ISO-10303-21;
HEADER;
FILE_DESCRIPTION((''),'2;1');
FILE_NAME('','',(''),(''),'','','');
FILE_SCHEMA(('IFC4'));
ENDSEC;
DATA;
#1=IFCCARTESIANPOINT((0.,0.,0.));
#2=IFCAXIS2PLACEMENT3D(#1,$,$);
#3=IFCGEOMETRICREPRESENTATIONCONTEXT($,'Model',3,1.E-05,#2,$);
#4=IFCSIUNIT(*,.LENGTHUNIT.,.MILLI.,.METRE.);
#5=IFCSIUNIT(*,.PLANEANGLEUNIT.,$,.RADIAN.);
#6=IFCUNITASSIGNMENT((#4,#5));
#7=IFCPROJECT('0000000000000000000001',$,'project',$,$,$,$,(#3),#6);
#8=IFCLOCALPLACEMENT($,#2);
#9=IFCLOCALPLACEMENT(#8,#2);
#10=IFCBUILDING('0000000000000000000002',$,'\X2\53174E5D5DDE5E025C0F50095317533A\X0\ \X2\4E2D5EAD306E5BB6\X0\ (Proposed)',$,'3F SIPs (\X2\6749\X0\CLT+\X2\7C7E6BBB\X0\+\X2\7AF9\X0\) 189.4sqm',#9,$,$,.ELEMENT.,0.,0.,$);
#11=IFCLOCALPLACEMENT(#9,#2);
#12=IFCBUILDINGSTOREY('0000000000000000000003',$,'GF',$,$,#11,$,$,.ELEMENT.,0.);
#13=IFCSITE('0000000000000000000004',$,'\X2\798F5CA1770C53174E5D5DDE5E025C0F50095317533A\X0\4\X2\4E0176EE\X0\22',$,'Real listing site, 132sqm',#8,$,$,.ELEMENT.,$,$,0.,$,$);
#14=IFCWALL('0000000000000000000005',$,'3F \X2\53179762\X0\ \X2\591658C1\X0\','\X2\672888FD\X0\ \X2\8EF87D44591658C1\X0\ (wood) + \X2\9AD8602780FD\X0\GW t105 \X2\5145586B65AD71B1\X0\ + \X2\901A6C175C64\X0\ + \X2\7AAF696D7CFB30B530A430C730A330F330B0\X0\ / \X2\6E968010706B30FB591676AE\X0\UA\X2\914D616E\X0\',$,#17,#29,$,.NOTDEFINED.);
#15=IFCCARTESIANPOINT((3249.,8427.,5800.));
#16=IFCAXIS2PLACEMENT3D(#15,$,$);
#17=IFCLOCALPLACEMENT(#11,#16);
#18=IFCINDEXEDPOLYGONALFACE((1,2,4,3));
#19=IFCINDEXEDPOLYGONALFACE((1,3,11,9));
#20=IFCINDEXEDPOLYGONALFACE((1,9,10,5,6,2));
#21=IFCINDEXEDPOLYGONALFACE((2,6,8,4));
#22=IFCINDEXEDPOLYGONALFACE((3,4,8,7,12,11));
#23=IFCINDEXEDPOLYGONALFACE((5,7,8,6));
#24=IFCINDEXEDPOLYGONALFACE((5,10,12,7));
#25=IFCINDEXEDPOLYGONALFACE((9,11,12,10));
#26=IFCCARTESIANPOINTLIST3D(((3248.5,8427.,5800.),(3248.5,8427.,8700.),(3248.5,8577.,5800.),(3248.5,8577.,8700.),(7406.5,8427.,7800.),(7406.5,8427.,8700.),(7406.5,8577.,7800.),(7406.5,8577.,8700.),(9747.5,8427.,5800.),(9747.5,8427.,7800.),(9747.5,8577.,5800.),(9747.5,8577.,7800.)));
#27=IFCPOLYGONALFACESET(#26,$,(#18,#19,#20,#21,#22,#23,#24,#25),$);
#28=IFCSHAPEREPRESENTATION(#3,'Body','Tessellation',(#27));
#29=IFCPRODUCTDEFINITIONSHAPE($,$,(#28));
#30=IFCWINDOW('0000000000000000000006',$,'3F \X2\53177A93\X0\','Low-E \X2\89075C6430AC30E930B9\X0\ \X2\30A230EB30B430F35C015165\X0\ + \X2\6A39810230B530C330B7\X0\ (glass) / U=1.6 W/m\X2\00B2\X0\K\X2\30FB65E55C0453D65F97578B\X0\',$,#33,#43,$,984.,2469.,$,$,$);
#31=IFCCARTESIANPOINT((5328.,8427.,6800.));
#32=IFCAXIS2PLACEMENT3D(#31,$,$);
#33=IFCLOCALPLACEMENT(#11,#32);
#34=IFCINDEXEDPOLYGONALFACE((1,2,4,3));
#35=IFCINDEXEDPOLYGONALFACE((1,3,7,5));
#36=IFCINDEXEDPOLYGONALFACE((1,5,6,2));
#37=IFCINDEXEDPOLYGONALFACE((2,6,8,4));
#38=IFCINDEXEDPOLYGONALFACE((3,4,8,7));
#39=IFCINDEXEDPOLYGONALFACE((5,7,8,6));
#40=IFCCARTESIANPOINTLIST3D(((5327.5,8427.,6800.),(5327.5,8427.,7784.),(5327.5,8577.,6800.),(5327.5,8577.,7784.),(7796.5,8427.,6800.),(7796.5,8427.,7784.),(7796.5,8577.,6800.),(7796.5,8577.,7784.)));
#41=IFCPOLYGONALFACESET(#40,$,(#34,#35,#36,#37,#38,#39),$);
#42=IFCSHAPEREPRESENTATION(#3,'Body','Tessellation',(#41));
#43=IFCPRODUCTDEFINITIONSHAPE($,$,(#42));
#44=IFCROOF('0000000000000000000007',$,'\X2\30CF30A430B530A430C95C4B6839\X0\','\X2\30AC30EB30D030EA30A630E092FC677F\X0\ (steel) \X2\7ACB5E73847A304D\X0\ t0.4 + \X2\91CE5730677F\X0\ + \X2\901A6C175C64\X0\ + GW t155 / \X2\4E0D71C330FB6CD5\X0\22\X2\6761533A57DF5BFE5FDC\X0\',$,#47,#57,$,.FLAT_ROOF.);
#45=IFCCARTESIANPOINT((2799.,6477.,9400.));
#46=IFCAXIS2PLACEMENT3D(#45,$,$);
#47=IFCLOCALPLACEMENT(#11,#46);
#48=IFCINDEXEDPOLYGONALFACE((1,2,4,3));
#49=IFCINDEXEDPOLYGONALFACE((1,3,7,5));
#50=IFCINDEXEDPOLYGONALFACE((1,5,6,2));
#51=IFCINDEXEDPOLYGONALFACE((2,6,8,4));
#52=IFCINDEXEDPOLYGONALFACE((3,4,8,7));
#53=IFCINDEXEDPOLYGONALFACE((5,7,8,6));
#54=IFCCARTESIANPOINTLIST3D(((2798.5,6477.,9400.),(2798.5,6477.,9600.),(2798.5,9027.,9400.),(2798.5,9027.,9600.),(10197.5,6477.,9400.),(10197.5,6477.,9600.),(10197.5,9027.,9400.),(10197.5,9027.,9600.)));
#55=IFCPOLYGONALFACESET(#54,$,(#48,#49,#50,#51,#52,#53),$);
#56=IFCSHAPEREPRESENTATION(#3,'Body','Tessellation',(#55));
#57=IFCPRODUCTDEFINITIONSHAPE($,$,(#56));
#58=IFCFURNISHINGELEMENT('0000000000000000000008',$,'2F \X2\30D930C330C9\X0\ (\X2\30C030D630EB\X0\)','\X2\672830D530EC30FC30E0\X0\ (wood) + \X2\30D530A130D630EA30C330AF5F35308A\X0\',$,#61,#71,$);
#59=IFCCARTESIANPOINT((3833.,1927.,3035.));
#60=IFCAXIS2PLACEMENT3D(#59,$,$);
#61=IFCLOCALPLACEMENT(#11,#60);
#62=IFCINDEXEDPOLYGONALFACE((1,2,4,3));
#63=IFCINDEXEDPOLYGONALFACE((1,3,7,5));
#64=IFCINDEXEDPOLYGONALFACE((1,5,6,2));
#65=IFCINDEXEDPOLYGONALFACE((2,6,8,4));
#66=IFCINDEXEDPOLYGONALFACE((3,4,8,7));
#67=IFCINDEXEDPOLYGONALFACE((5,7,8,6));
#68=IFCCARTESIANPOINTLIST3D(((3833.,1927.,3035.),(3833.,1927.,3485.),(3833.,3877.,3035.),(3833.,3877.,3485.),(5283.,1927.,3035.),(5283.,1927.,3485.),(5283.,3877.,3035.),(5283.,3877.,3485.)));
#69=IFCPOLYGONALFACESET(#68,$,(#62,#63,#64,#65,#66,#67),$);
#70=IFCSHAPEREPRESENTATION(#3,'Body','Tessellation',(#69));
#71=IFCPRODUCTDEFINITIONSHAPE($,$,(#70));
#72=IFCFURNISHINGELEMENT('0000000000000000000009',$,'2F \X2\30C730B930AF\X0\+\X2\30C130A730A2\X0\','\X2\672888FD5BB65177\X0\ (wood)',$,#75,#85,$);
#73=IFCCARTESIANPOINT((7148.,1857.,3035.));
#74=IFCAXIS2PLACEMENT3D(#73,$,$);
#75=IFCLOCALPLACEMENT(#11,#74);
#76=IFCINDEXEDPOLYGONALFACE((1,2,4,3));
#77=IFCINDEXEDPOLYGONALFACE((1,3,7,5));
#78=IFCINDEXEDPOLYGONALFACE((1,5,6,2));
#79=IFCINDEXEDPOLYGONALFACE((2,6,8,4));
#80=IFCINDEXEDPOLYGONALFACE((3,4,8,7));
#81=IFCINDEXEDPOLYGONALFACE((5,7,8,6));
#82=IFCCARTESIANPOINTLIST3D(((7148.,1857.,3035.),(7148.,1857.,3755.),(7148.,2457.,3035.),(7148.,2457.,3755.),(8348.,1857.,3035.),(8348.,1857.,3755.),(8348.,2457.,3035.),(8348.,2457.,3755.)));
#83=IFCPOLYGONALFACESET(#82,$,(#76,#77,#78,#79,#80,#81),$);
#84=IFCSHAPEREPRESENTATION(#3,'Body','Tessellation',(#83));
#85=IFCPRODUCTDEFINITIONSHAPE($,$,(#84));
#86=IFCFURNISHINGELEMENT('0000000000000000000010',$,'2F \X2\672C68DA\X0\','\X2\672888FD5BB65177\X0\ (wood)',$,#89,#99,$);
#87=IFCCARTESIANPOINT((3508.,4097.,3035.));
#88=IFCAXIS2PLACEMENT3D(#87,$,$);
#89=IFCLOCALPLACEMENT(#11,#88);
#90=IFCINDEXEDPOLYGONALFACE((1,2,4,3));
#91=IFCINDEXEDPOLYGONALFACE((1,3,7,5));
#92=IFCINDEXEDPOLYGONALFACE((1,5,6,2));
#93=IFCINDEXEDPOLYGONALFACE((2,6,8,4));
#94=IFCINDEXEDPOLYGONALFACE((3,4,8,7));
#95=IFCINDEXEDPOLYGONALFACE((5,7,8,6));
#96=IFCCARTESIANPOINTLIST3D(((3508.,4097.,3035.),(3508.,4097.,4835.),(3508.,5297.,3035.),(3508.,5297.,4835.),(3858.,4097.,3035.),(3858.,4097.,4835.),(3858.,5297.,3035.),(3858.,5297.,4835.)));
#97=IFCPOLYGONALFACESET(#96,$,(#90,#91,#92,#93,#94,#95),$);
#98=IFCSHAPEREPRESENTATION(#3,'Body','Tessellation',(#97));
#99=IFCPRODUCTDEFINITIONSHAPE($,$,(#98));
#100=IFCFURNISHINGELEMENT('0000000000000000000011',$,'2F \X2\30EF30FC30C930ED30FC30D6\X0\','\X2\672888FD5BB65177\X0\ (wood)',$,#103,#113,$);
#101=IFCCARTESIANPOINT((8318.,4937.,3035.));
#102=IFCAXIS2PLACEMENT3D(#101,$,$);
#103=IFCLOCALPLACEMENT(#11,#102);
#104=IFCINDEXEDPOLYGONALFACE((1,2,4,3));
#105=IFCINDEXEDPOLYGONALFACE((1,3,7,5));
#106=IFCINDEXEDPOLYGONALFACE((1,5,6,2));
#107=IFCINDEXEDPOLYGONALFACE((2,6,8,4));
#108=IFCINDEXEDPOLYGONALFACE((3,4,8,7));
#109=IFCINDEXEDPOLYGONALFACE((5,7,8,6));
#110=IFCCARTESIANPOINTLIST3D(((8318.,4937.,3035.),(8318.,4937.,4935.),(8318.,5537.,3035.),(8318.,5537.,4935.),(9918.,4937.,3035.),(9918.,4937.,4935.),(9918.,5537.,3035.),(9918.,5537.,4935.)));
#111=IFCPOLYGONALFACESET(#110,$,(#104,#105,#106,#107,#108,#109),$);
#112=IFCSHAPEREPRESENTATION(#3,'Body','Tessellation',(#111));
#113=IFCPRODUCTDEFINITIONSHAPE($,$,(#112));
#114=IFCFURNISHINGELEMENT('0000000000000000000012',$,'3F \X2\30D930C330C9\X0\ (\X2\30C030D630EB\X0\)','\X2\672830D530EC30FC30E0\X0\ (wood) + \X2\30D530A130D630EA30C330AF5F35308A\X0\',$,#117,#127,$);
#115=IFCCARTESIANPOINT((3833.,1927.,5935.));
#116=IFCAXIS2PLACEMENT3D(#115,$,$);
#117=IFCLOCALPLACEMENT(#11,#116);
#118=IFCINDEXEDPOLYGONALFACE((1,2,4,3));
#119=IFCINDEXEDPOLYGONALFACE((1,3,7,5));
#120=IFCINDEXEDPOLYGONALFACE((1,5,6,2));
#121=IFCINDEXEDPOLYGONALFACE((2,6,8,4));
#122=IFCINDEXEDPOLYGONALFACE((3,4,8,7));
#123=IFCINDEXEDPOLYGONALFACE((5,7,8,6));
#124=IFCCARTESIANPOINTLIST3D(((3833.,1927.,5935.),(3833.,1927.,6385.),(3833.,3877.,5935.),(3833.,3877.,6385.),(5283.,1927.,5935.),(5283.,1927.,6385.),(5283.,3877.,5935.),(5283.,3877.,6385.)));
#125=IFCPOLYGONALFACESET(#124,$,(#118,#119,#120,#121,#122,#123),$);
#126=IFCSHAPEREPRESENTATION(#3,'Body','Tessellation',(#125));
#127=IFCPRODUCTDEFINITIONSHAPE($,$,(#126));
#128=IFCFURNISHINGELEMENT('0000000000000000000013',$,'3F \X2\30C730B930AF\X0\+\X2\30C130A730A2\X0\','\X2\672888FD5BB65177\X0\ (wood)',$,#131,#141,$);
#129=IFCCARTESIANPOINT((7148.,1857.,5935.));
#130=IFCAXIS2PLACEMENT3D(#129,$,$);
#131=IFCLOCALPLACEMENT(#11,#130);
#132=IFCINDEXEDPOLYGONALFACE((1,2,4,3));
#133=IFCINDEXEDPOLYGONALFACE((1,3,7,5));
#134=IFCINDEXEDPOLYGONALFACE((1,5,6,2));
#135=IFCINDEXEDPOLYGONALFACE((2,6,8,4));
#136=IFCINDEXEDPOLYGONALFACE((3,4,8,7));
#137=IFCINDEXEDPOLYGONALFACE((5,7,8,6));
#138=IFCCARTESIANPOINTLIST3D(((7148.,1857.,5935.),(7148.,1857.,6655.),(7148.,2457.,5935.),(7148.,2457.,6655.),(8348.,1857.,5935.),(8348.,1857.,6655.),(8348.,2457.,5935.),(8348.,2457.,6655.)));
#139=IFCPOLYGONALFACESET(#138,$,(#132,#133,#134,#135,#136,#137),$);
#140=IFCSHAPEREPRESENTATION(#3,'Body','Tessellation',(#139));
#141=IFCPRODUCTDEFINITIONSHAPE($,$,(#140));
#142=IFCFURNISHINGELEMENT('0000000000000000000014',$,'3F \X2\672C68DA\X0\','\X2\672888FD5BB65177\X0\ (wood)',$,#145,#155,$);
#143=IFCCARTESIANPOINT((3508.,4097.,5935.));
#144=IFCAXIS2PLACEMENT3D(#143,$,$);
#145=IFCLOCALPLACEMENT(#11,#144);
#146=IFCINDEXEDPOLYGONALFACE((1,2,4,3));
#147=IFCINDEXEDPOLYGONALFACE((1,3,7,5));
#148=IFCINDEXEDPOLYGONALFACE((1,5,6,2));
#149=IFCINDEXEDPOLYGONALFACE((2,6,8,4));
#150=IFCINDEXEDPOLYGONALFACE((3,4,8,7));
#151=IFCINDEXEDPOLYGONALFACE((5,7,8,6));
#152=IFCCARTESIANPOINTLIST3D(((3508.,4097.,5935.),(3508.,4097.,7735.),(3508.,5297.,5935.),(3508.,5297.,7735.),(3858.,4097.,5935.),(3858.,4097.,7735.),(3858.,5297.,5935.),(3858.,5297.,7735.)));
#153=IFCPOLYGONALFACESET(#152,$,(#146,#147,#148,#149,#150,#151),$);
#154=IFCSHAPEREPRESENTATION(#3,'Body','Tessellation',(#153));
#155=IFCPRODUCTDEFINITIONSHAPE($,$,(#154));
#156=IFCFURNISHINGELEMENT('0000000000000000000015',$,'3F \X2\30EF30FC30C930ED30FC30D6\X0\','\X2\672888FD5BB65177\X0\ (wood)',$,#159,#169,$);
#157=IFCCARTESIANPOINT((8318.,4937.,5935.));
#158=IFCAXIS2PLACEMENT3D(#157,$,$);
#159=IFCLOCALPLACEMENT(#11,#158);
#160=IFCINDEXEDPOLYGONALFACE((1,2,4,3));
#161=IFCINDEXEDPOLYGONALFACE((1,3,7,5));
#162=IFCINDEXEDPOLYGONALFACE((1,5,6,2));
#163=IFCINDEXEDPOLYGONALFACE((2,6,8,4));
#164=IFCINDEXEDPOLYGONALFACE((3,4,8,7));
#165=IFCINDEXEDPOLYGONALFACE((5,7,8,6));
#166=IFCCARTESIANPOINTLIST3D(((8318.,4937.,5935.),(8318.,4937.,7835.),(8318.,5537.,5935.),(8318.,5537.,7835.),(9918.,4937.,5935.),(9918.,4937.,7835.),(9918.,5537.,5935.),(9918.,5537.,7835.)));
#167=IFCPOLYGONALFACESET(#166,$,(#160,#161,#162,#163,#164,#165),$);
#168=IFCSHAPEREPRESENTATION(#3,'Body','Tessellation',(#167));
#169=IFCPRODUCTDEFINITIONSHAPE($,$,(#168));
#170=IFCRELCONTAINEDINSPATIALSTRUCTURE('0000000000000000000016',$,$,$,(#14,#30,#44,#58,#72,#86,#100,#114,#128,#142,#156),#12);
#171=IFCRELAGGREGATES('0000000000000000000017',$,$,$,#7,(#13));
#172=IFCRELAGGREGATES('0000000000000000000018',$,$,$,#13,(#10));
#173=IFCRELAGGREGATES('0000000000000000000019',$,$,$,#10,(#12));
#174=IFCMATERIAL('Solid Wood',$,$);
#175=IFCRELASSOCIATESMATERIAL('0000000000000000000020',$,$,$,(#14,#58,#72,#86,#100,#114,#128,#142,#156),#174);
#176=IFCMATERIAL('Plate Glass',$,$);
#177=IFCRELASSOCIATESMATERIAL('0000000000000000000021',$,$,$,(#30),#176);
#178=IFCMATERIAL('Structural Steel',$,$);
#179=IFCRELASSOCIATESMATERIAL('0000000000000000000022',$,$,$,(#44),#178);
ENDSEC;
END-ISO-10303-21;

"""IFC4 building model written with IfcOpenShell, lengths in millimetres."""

from ifc_helpers import new_model, si_unit, frame, frame_2d, origin, place, context, project, spatial, rectangle, extrude, material, element, fill, save


model = new_model("IFC4")

# Units and contexts
model_context = context("Model", 3, precision=1e-05, world=origin())
ifc_project = project(units=[si_unit("LENGTHUNIT", "METRE", prefix="MILLI"), si_unit("PLANEANGLEUNIT", "RADIAN")], contexts=[model_context])

# Site, building, storey
site_placement = place(None, origin())
site = spatial("IfcSite", under=ifc_project, at=site_placement, Name="福岡県北九州市小倉北区4丁目22", ObjectType="Real listing site, 132sqm", CompositionType="ELEMENT", RefElevation=0.0)
building_placement = place(site_placement, origin())
building = spatial("IfcBuilding", under=site, at=building_placement, Name="北九州市小倉北区 中庭の家 (Proposed)", ObjectType="3F SIPs (杉CLT+籾殻+竹) 189.4sqm", CompositionType="ELEMENT", ElevationOfRefHeight=0.0, ElevationOfTerrain=0.0)
storey_placement = place(building_placement, origin())
storey = spatial("IfcBuildingStorey", under=building, at=storey_placement, Name="GF", CompositionType="ELEMENT", Elevation=0.0)

# Shared definitions
ifc_material_1 = material(Name="Solid Wood")

# Wall, opening, window
wall_1_placement = place(storey_placement, frame((3249.0, 8427.0, 5800.0)))
wall_1 = element("IfcWall", 1, at=wall_1_placement, inside=storey, material=ifc_material_1, Name="3F 北面 外壁", Description="木製 軸組外壁 (wood) + 高性能GW t105 充填断熱 + 通気層 + 窯業系サイディング / 準耐火・外皮UA配慮", PredefinedType="NOTDEFINED", context=model_context, shape_type="SweptSolid", body=[
    extrude(rectangle(XDim=6499.0, YDim=150.0, at=frame_2d((3249.0, 75.0))), frame((3249.0, 8427.0, 5800.0)), (0.0, 0.0, 1.0), 2900.0),
])
opening_1_placement = place(storey_placement, frame((5328.0, 8427.0, 6800.0)))
opening_1 = element("IfcOpeningElement", 2, at=opening_1_placement, cuts=wall_1, PredefinedType="NOTDEFINED", context=model_context, shape_type="SweptSolid", body=[
    extrude(rectangle(XDim=2469.0, YDim=150.0, at=frame_2d((1234.0, 75.0))), frame((5328.0, 8427.0, 6800.0)), (0.0, 0.0, 1.0), 984.0),
])
ifc_material_2 = material(Name="Plate Glass")
window_1_placement = place(storey_placement, frame((5328.0, 8427.0, 6800.0)))
window_1 = element("IfcWindow", 3, at=window_1_placement, inside=storey, material=ifc_material_2, Name="3F 北窓", Description="Low-E 複層ガラス アルゴン封入 + 樹脂サッシ (glass) / U=1.6 W/m²K・日射取得型", OverallHeight=984.0, OverallWidth=2469.0, context=model_context, shape_type="SweptSolid", body=[
    extrude(rectangle(XDim=2469.0, YDim=150.0, at=frame_2d((1234.0, 75.0))), frame((5328.0, 8427.0, 6800.0)), (0.0, 0.0, 1.0), 984.0),
])
fill(opening_1, window_1)

# Roof
ifc_material_3 = material(Name="Structural Steel")
roof_placement = place(storey_placement, frame((2799.0, 6477.0, 9400.0)))
element("IfcRoof", 4, at=roof_placement, inside=storey, material=ifc_material_3, Name="ハイサイド屋根", Description="ガルバリウム鋼板 (steel) 立平葺き t0.4 + 野地板 + 通気層 + GW t155 / 不燃・法22条区域対応", PredefinedType="FLAT_ROOF", context=model_context, shape_type="SweptSolid", body=[
    extrude(rectangle(XDim=7399.0, YDim=2550.0, at=frame_2d((3699.0, 1275.0))), frame((2799.0, 6477.0, 9400.0)), (0.0, 0.0, 1.0), 200.0),
])

# Furnishing elements
furnishing_1_placement = place(storey_placement, frame((3833.0, 1927.0, 3035.0)))
element("IfcFurnishingElement", 5, at=furnishing_1_placement, inside=storey, material=ifc_material_1, Name="2F ベッド (ダブル)", Description="木フレーム (wood) + ファブリック張り", context=model_context, shape_type="SweptSolid", body=[
    extrude(rectangle(XDim=1450.0, YDim=1950.0, at=frame_2d((725.0, 975.0))), frame((3833.0, 1927.0, 3035.0)), (0.0, 0.0, 1.0), 450.0),
])
furnishing_2_placement = place(storey_placement, frame((7148.0, 1857.0, 3035.0)))
element("IfcFurnishingElement", 6, at=furnishing_2_placement, inside=storey, material=ifc_material_1, Name="2F デスク+チェア", Description="木製家具 (wood)", context=model_context, shape_type="SweptSolid", body=[
    extrude(rectangle(XDim=1200.0, YDim=600.0, at=frame_2d((600.0, 300.0))), frame((7148.0, 1857.0, 3035.0)), (0.0, 0.0, 1.0), 720.0),
])
furnishing_3_placement = place(storey_placement, frame((3508.0, 4097.0, 3035.0)))
element("IfcFurnishingElement", 7, at=furnishing_3_placement, inside=storey, material=ifc_material_1, Name="2F 本棚", Description="木製家具 (wood)", context=model_context, shape_type="SweptSolid", body=[
    extrude(rectangle(XDim=350.0, YDim=1200.0, at=frame_2d((175.0, 600.0))), frame((3508.0, 4097.0, 3035.0)), (0.0, 0.0, 1.0), 1800.0),
])
furnishing_4_placement = place(storey_placement, frame((8318.0, 4937.0, 3035.0)))
element("IfcFurnishingElement", 8, at=furnishing_4_placement, inside=storey, material=ifc_material_1, Name="2F ワードローブ", Description="木製家具 (wood)", context=model_context, shape_type="SweptSolid", body=[
    extrude(rectangle(XDim=1600.0, YDim=600.0, at=frame_2d((800.0, 300.0))), frame((8318.0, 4937.0, 3035.0)), (0.0, 0.0, 1.0), 1900.0),
])
furnishing_5_placement = place(storey_placement, frame((3833.0, 1927.0, 5935.0)))
element("IfcFurnishingElement", 9, at=furnishing_5_placement, inside=storey, material=ifc_material_1, Name="3F ベッド (ダブル)", Description="木フレーム (wood) + ファブリック張り", context=model_context, shape_type="SweptSolid", body=[
    extrude(rectangle(XDim=1450.0, YDim=1950.0, at=frame_2d((725.0, 975.0))), frame((3833.0, 1927.0, 5935.0)), (0.0, 0.0, 1.0), 450.0),
])
furnishing_6_placement = place(storey_placement, frame((7148.0, 1857.0, 5935.0)))
element("IfcFurnishingElement", 10, at=furnishing_6_placement, inside=storey, material=ifc_material_1, Name="3F デスク+チェア", Description="木製家具 (wood)", context=model_context, shape_type="SweptSolid", body=[
    extrude(rectangle(XDim=1200.0, YDim=600.0, at=frame_2d((600.0, 300.0))), frame((7148.0, 1857.0, 5935.0)), (0.0, 0.0, 1.0), 720.0),
])
furnishing_7_placement = place(storey_placement, frame((3508.0, 4097.0, 5935.0)))
element("IfcFurnishingElement", 11, at=furnishing_7_placement, inside=storey, material=ifc_material_1, Name="3F 本棚", Description="木製家具 (wood)", context=model_context, shape_type="SweptSolid", body=[
    extrude(rectangle(XDim=350.0, YDim=1200.0, at=frame_2d((175.0, 600.0))), frame((3508.0, 4097.0, 5935.0)), (0.0, 0.0, 1.0), 1800.0),
])
furnishing_8_placement = place(storey_placement, frame((8318.0, 4937.0, 5935.0)))
element("IfcFurnishingElement", 12, at=furnishing_8_placement, inside=storey, material=ifc_material_1, Name="3F ワードローブ", Description="木製家具 (wood)", context=model_context, shape_type="SweptSolid", body=[
    extrude(rectangle(XDim=1600.0, YDim=600.0, at=frame_2d((800.0, 300.0))), frame((8318.0, 4937.0, 5935.0)), (0.0, 0.0, 1.0), 1900.0),
])

save(model, "model.ifc")
